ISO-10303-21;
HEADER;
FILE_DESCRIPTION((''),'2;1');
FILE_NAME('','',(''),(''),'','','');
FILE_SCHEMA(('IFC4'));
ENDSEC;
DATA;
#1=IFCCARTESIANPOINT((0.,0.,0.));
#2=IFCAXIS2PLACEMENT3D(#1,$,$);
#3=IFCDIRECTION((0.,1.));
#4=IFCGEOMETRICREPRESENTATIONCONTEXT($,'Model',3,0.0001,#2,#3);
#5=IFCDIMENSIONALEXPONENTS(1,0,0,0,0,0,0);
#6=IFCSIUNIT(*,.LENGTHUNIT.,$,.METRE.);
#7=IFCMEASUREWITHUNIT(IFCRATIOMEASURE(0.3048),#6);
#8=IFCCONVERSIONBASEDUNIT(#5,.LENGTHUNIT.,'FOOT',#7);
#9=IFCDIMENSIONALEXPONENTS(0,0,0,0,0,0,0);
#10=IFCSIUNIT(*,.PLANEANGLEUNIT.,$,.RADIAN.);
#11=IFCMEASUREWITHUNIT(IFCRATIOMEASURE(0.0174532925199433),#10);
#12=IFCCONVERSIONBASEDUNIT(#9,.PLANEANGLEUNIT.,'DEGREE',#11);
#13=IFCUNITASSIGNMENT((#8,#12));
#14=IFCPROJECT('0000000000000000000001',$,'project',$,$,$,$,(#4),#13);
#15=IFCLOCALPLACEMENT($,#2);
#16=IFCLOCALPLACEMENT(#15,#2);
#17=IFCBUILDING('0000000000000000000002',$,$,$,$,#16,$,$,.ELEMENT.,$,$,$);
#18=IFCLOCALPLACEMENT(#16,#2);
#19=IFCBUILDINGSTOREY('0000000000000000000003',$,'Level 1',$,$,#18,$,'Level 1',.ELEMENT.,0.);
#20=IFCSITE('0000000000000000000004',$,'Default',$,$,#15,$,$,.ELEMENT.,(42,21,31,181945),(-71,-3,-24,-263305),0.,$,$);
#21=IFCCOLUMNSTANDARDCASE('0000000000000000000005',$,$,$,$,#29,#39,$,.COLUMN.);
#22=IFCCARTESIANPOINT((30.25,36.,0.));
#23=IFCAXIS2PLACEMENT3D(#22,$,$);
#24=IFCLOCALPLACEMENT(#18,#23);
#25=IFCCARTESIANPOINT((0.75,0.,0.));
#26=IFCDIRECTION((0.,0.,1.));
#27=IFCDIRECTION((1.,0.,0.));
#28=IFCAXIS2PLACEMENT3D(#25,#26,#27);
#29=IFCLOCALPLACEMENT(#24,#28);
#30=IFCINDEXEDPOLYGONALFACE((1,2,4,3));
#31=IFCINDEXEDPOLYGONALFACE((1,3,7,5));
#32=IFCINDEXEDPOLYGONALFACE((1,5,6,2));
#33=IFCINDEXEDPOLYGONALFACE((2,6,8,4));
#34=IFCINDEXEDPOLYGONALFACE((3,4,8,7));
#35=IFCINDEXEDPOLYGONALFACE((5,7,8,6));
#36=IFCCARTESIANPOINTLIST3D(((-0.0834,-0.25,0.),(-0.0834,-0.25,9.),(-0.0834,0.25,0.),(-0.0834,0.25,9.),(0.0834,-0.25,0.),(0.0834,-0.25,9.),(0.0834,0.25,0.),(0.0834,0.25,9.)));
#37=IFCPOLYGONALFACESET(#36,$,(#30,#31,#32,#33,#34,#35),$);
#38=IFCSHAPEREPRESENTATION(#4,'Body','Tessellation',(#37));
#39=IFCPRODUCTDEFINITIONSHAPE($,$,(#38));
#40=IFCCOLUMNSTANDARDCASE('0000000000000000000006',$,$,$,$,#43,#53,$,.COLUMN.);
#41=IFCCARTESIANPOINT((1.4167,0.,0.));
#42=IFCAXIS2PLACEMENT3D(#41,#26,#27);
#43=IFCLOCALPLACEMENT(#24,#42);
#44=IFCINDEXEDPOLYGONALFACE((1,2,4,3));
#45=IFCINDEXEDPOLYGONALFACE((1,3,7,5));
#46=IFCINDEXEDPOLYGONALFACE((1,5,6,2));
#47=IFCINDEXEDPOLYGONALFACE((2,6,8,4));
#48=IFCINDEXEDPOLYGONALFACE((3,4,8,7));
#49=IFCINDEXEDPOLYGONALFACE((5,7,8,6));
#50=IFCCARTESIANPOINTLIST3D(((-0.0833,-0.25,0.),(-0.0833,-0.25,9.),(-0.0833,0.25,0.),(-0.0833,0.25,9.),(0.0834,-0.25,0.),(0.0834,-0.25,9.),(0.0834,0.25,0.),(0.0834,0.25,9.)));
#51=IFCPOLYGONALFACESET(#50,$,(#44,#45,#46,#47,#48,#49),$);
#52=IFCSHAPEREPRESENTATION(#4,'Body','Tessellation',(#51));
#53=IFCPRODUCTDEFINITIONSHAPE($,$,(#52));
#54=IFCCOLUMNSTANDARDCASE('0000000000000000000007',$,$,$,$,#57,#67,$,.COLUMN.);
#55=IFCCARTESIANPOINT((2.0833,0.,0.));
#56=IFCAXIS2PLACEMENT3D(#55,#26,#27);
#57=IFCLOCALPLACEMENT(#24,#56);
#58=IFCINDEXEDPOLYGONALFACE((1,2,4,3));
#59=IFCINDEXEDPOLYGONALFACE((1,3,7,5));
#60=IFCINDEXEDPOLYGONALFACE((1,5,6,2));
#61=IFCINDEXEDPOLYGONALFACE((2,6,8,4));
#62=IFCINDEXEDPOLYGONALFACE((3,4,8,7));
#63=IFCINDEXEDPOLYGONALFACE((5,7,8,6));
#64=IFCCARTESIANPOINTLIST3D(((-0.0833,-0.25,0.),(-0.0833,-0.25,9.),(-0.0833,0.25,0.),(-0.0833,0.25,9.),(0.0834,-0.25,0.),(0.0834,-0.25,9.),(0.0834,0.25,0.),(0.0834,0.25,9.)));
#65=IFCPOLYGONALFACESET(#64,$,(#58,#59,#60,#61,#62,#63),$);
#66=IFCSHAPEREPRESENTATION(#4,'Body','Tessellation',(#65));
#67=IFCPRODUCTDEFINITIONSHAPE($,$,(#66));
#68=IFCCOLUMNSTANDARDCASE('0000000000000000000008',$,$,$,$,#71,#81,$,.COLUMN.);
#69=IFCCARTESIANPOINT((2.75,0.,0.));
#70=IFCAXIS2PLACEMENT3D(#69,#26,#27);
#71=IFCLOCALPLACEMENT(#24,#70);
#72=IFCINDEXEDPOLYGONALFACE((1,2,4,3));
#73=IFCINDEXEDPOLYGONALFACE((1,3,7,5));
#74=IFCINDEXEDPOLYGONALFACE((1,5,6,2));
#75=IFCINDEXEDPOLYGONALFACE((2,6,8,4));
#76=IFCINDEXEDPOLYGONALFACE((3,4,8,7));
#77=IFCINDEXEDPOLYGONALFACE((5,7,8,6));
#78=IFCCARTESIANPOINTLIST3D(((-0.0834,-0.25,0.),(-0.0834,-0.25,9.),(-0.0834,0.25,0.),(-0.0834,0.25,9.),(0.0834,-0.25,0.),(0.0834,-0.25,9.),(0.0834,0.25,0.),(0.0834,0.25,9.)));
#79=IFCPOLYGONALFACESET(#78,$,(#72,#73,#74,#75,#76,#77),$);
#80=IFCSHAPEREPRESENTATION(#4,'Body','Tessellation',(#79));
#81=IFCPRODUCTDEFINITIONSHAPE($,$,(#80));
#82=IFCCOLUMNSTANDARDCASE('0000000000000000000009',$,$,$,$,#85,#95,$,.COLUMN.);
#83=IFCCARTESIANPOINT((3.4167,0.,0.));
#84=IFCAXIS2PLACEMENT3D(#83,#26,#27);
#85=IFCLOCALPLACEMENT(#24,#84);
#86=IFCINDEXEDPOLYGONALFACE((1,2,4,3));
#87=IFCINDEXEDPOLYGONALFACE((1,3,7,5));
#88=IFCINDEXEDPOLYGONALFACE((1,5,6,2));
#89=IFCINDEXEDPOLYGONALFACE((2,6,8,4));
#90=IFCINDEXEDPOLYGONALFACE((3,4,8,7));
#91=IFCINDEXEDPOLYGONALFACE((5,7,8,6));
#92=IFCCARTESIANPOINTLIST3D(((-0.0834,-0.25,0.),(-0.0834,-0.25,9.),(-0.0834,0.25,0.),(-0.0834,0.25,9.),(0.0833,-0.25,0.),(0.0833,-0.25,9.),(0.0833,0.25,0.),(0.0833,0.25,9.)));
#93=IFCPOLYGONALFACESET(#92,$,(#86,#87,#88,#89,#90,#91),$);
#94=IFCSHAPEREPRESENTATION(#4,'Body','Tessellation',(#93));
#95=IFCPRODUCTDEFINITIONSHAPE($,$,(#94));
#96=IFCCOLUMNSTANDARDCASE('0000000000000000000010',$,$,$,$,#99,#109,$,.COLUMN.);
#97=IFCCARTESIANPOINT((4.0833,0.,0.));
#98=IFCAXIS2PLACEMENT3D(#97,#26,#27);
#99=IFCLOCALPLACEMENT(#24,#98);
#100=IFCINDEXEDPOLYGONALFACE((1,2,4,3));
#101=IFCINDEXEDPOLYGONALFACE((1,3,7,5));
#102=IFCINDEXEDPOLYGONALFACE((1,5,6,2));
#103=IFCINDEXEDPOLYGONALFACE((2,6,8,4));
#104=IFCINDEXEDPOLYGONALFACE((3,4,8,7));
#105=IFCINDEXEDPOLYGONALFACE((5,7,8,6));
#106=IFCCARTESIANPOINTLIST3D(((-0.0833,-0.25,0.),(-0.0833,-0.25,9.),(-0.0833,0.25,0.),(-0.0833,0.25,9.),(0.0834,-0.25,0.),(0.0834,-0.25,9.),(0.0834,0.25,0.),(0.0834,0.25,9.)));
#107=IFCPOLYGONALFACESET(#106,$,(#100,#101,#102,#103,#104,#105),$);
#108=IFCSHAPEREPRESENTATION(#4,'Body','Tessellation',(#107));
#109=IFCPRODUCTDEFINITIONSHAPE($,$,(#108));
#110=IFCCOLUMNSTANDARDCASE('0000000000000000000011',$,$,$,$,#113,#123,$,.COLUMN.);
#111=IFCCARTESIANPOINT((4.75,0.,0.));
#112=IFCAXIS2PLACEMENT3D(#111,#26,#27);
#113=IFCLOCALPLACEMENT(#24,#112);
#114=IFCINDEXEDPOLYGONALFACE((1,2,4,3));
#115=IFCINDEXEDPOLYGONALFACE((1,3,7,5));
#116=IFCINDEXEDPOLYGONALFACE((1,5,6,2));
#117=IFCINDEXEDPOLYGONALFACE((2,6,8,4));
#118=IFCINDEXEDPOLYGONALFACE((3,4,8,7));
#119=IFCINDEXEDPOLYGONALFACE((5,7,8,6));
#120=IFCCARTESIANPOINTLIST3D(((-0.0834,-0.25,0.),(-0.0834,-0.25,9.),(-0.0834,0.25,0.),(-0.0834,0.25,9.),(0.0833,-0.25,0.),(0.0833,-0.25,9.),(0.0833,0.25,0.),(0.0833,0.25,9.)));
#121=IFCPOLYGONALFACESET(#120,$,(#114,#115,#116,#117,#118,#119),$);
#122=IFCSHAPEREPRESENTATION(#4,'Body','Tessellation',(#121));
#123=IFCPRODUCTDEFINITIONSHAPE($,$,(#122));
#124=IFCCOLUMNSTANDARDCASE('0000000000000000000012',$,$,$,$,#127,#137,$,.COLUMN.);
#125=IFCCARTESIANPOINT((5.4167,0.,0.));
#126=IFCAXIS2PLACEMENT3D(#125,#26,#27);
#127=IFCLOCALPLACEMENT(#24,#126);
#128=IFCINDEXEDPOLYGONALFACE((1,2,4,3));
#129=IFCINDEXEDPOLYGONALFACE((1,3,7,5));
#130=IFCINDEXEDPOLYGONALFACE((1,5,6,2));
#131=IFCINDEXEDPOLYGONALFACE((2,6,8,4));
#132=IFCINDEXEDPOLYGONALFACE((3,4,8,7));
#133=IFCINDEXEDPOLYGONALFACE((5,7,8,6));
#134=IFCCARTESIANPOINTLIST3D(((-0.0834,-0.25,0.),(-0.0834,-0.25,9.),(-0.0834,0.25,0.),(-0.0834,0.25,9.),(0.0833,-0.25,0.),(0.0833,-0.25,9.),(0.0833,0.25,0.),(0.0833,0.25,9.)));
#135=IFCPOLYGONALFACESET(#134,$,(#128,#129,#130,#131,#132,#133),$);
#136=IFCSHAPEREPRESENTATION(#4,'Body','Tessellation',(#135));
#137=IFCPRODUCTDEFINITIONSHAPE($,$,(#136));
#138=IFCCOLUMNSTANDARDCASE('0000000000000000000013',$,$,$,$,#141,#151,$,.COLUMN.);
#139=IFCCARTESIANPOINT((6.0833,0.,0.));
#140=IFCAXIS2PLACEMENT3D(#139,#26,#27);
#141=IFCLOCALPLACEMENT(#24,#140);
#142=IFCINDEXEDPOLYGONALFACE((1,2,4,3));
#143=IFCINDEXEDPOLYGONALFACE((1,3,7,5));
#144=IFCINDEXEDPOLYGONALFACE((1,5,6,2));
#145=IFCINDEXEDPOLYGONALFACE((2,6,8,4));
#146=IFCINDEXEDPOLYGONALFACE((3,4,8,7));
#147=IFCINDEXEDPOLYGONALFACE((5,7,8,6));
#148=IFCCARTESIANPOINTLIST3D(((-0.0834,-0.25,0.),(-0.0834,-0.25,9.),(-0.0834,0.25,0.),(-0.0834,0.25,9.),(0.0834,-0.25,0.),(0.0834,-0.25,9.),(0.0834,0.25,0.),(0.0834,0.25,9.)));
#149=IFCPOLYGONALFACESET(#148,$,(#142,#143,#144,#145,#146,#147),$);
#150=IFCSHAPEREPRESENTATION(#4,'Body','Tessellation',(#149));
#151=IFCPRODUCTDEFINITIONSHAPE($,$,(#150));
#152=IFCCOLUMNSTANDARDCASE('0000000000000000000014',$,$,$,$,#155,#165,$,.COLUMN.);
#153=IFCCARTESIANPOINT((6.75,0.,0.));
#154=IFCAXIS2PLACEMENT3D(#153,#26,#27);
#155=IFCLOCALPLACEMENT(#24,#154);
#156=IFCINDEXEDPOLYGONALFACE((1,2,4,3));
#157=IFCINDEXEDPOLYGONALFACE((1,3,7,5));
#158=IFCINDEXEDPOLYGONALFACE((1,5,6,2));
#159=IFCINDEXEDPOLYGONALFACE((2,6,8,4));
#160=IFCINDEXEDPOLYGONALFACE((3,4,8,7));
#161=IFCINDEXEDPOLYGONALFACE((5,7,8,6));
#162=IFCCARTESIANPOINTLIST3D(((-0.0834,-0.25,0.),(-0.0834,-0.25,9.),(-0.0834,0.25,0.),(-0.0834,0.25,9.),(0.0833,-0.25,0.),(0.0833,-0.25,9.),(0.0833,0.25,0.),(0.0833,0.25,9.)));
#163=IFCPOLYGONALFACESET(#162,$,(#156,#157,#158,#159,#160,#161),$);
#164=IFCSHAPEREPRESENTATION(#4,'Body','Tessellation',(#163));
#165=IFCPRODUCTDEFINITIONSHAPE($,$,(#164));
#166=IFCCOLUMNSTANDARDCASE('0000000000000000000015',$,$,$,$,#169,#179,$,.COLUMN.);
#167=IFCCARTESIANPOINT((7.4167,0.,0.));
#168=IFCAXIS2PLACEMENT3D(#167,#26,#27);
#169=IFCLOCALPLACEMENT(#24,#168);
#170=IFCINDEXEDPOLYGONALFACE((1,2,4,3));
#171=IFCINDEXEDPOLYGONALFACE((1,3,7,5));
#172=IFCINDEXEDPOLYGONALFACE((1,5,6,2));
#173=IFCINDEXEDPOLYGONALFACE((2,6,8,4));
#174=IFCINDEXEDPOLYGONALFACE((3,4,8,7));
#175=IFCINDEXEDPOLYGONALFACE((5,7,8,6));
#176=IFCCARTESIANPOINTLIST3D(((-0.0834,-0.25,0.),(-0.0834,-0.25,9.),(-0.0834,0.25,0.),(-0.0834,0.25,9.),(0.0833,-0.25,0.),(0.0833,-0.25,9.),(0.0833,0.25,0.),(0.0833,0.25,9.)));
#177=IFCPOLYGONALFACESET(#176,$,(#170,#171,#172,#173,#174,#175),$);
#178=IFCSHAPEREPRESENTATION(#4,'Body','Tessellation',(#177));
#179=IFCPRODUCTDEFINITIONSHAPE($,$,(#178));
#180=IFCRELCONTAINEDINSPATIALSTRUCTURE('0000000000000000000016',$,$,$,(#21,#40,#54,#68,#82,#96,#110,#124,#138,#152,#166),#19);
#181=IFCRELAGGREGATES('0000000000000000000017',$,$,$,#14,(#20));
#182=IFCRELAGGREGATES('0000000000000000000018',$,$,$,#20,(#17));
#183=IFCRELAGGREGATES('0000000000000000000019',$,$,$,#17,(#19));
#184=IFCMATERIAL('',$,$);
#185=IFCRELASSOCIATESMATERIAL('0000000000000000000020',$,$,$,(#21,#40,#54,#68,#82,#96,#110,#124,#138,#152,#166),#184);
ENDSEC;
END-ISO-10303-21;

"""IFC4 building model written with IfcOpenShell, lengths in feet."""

from ifc_helpers import new_model, entity, si_unit, converted_unit, direction, frame, origin, place, context, project, spatial, rectangle, extrude, material, element, save


model = new_model("IFC4")

# Units and contexts
model_context = context("Model", 3, precision=0.0001, world=origin(), true_north=direction((0.0, 1.0)))
ifc_project = project(units=[converted_unit("LENGTHUNIT", "FOOT", entity("IfcRatioMeasure", 0.3048), si_unit("LENGTHUNIT", "METRE"), dimensions=[1, 0, 0, 0, 0, 0, 0]), converted_unit("PLANEANGLEUNIT", "DEGREE", entity("IfcRatioMeasure", 0.0174532925199433), si_unit("PLANEANGLEUNIT", "RADIAN"), dimensions=[0, 0, 0, 0, 0, 0, 0])], contexts=[model_context])

# Site, building, storey
site_placement = place(None, origin())
site = spatial("IfcSite", under=ifc_project, at=site_placement, Name="Default", CompositionType="ELEMENT", RefLatitude=(42, 21, 31, 181945), RefLongitude=(-71, -3, -24, -263305), RefElevation=0.0)
building_placement = place(site_placement, origin())
building = spatial("IfcBuilding", under=site, at=building_placement, CompositionType="ELEMENT")
storey_placement = place(building_placement, origin())
storey = spatial("IfcBuildingStorey", under=building, at=storey_placement, Name="Level 1", LongName="Level 1", CompositionType="ELEMENT", Elevation=0.0)

# Columns
ifc_material_1 = material(Name="")
wall_placement = place(storey_placement, frame((30.25, 36.0, 0.0)))
for number, where, z_axis, x_axis in (
    (1, (0.75, 0.0, 0.0), (0.0, 0.0, 1.0), (1.0, 0.0, 0.0)),
    (2, (1.4167, 0.0, 0.0), (0.0, 0.0, 1.0), (1.0, 0.0, 0.0)),
    (3, (2.0833, 0.0, 0.0), (0.0, 0.0, 1.0), (1.0, 0.0, 0.0)),
    (4, (2.75, 0.0, 0.0), (0.0, 0.0, 1.0), (1.0, 0.0, 0.0)),
    (5, (3.4167, 0.0, 0.0), (0.0, 0.0, 1.0), (1.0, 0.0, 0.0)),
    (6, (4.0833, 0.0, 0.0), (0.0, 0.0, 1.0), (1.0, 0.0, 0.0)),
    (7, (4.75, 0.0, 0.0), (0.0, 0.0, 1.0), (1.0, 0.0, 0.0)),
    (8, (5.4167, 0.0, 0.0), (0.0, 0.0, 1.0), (1.0, 0.0, 0.0)),
    (9, (6.0833, 0.0, 0.0), (0.0, 0.0, 1.0), (1.0, 0.0, 0.0)),
    (10, (6.75, 0.0, 0.0), (0.0, 0.0, 1.0), (1.0, 0.0, 0.0)),
    (11, (7.4167, 0.0, 0.0), (0.0, 0.0, 1.0), (1.0, 0.0, 0.0)),
):
    element("IfcColumnStandardCase", number, at=place(wall_placement, frame(where, z_axis=z_axis, x_axis=x_axis)), inside=storey, material=ifc_material_1, PredefinedType="COLUMN", context=model_context, shape_type="SweptSolid", body=[
        extrude(rectangle(XDim=0.1667, YDim=0.5), origin(), (0.0, 0.0, 1.0), 9.0),
    ])

save(model, "model.ifc")
